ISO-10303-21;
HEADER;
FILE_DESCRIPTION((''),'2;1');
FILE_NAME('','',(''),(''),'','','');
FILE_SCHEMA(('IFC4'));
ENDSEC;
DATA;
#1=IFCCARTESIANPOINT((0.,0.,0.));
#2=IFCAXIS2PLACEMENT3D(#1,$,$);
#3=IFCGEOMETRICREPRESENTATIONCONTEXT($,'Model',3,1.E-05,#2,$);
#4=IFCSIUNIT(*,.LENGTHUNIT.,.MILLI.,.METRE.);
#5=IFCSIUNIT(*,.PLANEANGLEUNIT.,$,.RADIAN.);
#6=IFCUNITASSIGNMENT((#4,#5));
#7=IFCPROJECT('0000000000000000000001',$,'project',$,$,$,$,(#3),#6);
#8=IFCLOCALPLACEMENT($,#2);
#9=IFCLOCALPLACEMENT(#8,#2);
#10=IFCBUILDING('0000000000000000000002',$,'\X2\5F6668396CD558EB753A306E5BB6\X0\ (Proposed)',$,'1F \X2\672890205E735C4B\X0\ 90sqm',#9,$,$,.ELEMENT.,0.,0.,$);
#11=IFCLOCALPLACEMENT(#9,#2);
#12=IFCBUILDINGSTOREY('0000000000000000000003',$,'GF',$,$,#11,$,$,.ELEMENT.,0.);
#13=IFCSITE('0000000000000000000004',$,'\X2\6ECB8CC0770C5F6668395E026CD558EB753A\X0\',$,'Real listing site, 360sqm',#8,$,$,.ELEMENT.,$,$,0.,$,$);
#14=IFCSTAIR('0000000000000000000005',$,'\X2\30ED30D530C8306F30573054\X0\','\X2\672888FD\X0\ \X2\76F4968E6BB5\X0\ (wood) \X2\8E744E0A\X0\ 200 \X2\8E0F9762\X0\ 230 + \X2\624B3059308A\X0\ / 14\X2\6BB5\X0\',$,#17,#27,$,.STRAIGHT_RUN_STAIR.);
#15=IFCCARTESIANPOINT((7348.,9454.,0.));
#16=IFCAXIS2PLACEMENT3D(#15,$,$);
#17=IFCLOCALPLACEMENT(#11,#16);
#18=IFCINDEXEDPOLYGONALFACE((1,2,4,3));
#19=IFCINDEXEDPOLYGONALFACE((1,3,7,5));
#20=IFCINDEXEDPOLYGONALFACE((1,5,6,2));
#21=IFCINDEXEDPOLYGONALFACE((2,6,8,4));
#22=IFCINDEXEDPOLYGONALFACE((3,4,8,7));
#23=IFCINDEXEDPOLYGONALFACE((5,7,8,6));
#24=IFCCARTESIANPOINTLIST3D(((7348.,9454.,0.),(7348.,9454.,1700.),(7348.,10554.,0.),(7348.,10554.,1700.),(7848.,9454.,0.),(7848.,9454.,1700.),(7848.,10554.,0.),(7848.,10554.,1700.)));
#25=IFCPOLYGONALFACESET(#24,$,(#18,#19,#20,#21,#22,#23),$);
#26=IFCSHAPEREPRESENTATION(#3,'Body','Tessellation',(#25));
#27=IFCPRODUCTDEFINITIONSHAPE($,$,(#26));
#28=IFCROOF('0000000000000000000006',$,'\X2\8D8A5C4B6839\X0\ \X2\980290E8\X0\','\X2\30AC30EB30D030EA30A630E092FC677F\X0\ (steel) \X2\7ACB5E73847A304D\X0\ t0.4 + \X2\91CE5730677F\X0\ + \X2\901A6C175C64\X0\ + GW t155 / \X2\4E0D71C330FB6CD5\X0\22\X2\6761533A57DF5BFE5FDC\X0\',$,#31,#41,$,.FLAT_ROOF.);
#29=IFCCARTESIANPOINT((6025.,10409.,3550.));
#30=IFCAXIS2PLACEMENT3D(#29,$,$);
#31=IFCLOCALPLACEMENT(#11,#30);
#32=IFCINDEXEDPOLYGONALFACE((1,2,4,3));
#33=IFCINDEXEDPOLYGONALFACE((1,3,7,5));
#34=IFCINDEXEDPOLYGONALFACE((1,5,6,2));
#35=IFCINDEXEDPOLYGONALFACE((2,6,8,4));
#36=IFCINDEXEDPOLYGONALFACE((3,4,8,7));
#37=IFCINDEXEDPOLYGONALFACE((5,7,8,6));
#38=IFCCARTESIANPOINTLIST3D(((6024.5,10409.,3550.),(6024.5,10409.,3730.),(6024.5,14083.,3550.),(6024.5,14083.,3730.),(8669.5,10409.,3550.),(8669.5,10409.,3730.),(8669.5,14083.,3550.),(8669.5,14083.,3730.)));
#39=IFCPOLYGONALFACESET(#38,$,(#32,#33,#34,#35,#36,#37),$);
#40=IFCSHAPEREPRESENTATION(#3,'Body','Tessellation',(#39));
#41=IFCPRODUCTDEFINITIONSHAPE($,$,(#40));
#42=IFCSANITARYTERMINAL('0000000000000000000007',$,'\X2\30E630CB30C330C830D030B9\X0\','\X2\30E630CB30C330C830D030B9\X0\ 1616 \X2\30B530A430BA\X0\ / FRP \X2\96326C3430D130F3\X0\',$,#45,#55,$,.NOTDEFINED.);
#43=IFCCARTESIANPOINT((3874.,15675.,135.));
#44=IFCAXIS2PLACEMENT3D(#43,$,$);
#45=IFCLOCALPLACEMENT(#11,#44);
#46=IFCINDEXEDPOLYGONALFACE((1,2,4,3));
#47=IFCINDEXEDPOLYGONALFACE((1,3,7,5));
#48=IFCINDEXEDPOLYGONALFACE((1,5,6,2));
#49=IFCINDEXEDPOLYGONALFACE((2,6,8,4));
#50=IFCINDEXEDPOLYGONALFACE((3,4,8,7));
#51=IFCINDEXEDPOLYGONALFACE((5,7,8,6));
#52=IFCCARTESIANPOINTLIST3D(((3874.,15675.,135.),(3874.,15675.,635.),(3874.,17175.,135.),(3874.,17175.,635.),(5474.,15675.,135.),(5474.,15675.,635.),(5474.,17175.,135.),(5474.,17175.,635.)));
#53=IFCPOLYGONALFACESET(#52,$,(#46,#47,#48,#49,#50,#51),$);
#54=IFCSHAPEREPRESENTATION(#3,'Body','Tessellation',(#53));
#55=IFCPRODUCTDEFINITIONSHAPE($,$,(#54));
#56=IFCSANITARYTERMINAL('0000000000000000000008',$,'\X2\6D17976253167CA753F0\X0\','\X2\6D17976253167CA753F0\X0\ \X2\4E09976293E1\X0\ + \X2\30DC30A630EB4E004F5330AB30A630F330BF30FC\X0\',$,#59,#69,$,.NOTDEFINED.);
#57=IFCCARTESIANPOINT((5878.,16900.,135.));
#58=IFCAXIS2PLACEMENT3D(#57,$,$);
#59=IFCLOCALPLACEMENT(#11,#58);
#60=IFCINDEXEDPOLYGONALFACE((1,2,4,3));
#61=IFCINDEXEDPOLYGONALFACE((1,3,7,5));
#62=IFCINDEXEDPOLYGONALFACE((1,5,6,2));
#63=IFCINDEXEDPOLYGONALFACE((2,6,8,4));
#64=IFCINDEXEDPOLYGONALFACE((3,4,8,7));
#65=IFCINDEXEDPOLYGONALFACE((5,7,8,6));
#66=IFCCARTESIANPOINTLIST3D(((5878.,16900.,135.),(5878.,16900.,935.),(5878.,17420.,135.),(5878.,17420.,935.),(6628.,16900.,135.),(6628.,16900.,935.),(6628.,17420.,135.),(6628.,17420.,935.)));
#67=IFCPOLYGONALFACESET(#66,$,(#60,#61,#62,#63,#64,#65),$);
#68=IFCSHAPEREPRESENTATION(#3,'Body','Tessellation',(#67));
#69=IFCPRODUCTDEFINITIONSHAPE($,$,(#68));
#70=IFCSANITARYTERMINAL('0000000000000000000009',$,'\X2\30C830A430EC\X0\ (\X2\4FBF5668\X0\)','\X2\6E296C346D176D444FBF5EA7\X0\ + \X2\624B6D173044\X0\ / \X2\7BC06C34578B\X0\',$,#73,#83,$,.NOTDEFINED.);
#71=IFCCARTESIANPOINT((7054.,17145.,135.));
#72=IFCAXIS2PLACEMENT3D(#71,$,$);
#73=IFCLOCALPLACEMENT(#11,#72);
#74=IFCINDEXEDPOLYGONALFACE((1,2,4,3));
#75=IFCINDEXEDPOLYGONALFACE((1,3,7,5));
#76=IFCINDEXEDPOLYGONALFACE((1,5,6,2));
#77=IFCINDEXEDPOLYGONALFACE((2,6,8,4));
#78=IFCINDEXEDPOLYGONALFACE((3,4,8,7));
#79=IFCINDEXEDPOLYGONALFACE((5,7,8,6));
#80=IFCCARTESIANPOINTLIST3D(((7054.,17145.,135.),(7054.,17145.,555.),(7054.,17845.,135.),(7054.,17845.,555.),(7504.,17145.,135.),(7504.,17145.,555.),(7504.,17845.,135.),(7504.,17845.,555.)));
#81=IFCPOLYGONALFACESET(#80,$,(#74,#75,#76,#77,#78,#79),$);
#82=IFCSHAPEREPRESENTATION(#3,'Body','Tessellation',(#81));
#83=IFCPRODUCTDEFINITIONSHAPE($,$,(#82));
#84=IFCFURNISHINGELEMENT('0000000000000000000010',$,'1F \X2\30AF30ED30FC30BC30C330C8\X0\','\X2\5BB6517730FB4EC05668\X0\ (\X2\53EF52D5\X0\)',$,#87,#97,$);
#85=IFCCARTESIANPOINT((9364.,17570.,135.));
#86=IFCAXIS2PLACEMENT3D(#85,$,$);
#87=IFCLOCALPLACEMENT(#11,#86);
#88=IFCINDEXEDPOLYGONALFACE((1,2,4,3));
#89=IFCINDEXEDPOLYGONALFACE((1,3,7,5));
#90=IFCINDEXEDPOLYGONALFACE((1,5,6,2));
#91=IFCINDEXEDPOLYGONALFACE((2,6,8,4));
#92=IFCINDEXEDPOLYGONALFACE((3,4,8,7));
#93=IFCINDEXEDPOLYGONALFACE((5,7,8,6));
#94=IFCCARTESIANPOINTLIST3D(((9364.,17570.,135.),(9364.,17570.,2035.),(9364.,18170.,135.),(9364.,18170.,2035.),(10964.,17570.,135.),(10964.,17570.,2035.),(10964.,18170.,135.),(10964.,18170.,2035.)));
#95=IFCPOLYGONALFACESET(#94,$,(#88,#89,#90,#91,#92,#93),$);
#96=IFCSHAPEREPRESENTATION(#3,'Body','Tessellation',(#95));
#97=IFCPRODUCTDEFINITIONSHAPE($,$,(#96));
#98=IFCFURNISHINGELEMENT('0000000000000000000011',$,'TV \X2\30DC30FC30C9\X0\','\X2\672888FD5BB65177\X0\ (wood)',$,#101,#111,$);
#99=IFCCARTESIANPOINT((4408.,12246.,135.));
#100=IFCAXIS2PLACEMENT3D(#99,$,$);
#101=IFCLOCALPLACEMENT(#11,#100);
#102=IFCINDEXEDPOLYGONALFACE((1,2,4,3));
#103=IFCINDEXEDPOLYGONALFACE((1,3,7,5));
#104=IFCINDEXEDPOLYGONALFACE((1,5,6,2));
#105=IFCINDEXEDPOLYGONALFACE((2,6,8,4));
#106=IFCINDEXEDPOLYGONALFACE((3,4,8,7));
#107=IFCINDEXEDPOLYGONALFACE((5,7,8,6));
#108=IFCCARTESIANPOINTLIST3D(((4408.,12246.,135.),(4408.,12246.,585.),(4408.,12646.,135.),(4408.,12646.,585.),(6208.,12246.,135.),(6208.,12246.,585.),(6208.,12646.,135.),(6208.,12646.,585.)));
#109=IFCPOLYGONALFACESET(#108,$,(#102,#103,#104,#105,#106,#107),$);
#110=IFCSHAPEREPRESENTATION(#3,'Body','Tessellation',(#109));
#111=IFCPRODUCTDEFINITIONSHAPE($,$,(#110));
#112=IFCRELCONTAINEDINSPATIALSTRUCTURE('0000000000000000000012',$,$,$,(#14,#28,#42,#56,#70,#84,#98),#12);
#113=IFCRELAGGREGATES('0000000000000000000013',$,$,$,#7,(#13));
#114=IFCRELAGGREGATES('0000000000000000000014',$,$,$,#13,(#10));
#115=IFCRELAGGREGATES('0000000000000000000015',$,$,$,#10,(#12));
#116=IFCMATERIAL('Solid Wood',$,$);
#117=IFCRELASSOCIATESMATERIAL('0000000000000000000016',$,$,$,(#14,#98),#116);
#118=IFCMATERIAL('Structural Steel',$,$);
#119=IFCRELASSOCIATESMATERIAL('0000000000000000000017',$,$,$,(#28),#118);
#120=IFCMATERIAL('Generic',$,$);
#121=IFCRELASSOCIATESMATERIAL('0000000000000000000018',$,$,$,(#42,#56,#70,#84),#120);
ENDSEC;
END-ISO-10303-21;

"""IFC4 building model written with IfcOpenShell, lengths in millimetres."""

from ifc_helpers import new_model, si_unit, frame, frame_2d, origin, place, context, project, spatial, rectangle, extrude, material, element, save


model = new_model("IFC4")

# Units and contexts
model_context = context("Model", 3, precision=1e-05, world=origin())
ifc_project = project(units=[si_unit("LENGTHUNIT", "METRE", prefix="MILLI"), si_unit("PLANEANGLEUNIT", "RADIAN")], contexts=[model_context])

# Site, building, storey
site_placement = place(None, origin())
site = spatial("IfcSite", under=ifc_project, at=site_placement, Name="滋賀県彦根市法士町", ObjectType="Real listing site, 360sqm", CompositionType="ELEMENT", RefElevation=0.0)
building_placement = place(site_placement, origin())
building = spatial("IfcBuilding", under=site, at=building_placement, Name="彦根法士町の家 (Proposed)", ObjectType="1F 木造平屋 90sqm", CompositionType="ELEMENT", ElevationOfRefHeight=0.0, ElevationOfTerrain=0.0)
storey_placement = place(building_placement, origin())
storey = spatial("IfcBuildingStorey", under=building, at=storey_placement, Name="GF", CompositionType="ELEMENT", Elevation=0.0)

# Shared definitions
ifc_material_1 = material(Name="Solid Wood")

# Stair
stair_placement = place(storey_placement, frame((7348.0, 9454.0, 0.0)))
element("IfcStair", 1, at=stair_placement, inside=storey, material=ifc_material_1, Name="ロフトはしご", Description="木製 直階段 (wood) 蹴上 200 踏面 230 + 手すり / 14段", PredefinedType="STRAIGHT_RUN_STAIR", context=model_context, shape_type="SweptSolid", body=[
    extrude(rectangle(XDim=500.0, YDim=1100.0, at=frame_2d((250.0, 550.0))), frame((7348.0, 9454.0, 0.0)), (0.0, 0.0, 1.0), 1700.0),
])

# Roof
ifc_material_2 = material(Name="Structural Steel")
roof_placement = place(storey_placement, frame((6025.0, 10409.0, 3550.0)))
element("IfcRoof", 2, at=roof_placement, inside=storey, material=ifc_material_2, Name="越屋根 頂部", Description="ガルバリウム鋼板 (steel) 立平葺き t0.4 + 野地板 + 通気層 + GW t155 / 不燃・法22条区域対応", PredefinedType="FLAT_ROOF", context=model_context, shape_type="SweptSolid", body=[
    extrude(rectangle(XDim=2645.0, YDim=3674.0, at=frame_2d((1322.0, 1837.0))), frame((6025.0, 10409.0, 3550.0)), (0.0, 0.0, 1.0), 180.0),
])

# Sanitary terminals
ifc_material_3 = material(Name="Generic")
sanitary_terminal_1_placement = place(storey_placement, frame((3874.0, 15675.0, 135.0)))
element("IfcSanitaryTerminal", 3, at=sanitary_terminal_1_placement, inside=storey, material=ifc_material_3, Name="ユニットバス", Description="ユニットバス 1616 サイズ / FRP 防水パン", PredefinedType="NOTDEFINED", context=model_context, shape_type="SweptSolid", body=[
    extrude(rectangle(XDim=1600.0, YDim=1500.0, at=frame_2d((800.0, 750.0))), frame((3874.0, 15675.0, 135.0)), (0.0, 0.0, 1.0), 500.0),
])
sanitary_terminal_2_placement = place(storey_placement, frame((5878.0, 16900.0, 135.0)))
element("IfcSanitaryTerminal", 4, at=sanitary_terminal_2_placement, inside=storey, material=ifc_material_3, Name="洗面化粧台", Description="洗面化粧台 三面鏡 + ボウル一体カウンター", PredefinedType="NOTDEFINED", context=model_context, shape_type="SweptSolid", body=[
    extrude(rectangle(XDim=750.0, YDim=520.0, at=frame_2d((375.0, 260.0))), frame((5878.0, 16900.0, 135.0)), (0.0, 0.0, 1.0), 800.0),
])
sanitary_terminal_3_placement = place(storey_placement, frame((7054.0, 17145.0, 135.0)))
element("IfcSanitaryTerminal", 5, at=sanitary_terminal_3_placement, inside=storey, material=ifc_material_3, Name="トイレ (便器)", Description="温水洗浄便座 + 手洗い / 節水型", PredefinedType="NOTDEFINED", context=model_context, shape_type="SweptSolid", body=[
    extrude(rectangle(XDim=450.0, YDim=700.0, at=frame_2d((225.0, 350.0))), frame((7054.0, 17145.0, 135.0)), (0.0, 0.0, 1.0), 420.0),
])

# Furnishing elements
furnishing_1_placement = place(storey_placement, frame((9364.0, 17570.0, 135.0)))
element("IfcFurnishingElement", 6, at=furnishing_1_placement, inside=storey, material=ifc_material_3, Name="1F クローゼット", Description="家具・什器 (可動)", context=model_context, shape_type="SweptSolid", body=[
    extrude(rectangle(XDim=1600.0, YDim=600.0, at=frame_2d((800.0, 300.0))), frame((9364.0, 17570.0, 135.0)), (0.0, 0.0, 1.0), 1900.0),
])
furnishing_2_placement = place(storey_placement, frame((4408.0, 12246.0, 135.0)))
element("IfcFurnishingElement", 7, at=furnishing_2_placement, inside=storey, material=ifc_material_1, Name="TV ボード", Description="木製家具 (wood)", context=model_context, shape_type="SweptSolid", body=[
    extrude(rectangle(XDim=1800.0, YDim=400.0, at=frame_2d((900.0, 200.0))), frame((4408.0, 12246.0, 135.0)), (0.0, 0.0, 1.0), 450.0),
])

save(model, "model.ifc")
